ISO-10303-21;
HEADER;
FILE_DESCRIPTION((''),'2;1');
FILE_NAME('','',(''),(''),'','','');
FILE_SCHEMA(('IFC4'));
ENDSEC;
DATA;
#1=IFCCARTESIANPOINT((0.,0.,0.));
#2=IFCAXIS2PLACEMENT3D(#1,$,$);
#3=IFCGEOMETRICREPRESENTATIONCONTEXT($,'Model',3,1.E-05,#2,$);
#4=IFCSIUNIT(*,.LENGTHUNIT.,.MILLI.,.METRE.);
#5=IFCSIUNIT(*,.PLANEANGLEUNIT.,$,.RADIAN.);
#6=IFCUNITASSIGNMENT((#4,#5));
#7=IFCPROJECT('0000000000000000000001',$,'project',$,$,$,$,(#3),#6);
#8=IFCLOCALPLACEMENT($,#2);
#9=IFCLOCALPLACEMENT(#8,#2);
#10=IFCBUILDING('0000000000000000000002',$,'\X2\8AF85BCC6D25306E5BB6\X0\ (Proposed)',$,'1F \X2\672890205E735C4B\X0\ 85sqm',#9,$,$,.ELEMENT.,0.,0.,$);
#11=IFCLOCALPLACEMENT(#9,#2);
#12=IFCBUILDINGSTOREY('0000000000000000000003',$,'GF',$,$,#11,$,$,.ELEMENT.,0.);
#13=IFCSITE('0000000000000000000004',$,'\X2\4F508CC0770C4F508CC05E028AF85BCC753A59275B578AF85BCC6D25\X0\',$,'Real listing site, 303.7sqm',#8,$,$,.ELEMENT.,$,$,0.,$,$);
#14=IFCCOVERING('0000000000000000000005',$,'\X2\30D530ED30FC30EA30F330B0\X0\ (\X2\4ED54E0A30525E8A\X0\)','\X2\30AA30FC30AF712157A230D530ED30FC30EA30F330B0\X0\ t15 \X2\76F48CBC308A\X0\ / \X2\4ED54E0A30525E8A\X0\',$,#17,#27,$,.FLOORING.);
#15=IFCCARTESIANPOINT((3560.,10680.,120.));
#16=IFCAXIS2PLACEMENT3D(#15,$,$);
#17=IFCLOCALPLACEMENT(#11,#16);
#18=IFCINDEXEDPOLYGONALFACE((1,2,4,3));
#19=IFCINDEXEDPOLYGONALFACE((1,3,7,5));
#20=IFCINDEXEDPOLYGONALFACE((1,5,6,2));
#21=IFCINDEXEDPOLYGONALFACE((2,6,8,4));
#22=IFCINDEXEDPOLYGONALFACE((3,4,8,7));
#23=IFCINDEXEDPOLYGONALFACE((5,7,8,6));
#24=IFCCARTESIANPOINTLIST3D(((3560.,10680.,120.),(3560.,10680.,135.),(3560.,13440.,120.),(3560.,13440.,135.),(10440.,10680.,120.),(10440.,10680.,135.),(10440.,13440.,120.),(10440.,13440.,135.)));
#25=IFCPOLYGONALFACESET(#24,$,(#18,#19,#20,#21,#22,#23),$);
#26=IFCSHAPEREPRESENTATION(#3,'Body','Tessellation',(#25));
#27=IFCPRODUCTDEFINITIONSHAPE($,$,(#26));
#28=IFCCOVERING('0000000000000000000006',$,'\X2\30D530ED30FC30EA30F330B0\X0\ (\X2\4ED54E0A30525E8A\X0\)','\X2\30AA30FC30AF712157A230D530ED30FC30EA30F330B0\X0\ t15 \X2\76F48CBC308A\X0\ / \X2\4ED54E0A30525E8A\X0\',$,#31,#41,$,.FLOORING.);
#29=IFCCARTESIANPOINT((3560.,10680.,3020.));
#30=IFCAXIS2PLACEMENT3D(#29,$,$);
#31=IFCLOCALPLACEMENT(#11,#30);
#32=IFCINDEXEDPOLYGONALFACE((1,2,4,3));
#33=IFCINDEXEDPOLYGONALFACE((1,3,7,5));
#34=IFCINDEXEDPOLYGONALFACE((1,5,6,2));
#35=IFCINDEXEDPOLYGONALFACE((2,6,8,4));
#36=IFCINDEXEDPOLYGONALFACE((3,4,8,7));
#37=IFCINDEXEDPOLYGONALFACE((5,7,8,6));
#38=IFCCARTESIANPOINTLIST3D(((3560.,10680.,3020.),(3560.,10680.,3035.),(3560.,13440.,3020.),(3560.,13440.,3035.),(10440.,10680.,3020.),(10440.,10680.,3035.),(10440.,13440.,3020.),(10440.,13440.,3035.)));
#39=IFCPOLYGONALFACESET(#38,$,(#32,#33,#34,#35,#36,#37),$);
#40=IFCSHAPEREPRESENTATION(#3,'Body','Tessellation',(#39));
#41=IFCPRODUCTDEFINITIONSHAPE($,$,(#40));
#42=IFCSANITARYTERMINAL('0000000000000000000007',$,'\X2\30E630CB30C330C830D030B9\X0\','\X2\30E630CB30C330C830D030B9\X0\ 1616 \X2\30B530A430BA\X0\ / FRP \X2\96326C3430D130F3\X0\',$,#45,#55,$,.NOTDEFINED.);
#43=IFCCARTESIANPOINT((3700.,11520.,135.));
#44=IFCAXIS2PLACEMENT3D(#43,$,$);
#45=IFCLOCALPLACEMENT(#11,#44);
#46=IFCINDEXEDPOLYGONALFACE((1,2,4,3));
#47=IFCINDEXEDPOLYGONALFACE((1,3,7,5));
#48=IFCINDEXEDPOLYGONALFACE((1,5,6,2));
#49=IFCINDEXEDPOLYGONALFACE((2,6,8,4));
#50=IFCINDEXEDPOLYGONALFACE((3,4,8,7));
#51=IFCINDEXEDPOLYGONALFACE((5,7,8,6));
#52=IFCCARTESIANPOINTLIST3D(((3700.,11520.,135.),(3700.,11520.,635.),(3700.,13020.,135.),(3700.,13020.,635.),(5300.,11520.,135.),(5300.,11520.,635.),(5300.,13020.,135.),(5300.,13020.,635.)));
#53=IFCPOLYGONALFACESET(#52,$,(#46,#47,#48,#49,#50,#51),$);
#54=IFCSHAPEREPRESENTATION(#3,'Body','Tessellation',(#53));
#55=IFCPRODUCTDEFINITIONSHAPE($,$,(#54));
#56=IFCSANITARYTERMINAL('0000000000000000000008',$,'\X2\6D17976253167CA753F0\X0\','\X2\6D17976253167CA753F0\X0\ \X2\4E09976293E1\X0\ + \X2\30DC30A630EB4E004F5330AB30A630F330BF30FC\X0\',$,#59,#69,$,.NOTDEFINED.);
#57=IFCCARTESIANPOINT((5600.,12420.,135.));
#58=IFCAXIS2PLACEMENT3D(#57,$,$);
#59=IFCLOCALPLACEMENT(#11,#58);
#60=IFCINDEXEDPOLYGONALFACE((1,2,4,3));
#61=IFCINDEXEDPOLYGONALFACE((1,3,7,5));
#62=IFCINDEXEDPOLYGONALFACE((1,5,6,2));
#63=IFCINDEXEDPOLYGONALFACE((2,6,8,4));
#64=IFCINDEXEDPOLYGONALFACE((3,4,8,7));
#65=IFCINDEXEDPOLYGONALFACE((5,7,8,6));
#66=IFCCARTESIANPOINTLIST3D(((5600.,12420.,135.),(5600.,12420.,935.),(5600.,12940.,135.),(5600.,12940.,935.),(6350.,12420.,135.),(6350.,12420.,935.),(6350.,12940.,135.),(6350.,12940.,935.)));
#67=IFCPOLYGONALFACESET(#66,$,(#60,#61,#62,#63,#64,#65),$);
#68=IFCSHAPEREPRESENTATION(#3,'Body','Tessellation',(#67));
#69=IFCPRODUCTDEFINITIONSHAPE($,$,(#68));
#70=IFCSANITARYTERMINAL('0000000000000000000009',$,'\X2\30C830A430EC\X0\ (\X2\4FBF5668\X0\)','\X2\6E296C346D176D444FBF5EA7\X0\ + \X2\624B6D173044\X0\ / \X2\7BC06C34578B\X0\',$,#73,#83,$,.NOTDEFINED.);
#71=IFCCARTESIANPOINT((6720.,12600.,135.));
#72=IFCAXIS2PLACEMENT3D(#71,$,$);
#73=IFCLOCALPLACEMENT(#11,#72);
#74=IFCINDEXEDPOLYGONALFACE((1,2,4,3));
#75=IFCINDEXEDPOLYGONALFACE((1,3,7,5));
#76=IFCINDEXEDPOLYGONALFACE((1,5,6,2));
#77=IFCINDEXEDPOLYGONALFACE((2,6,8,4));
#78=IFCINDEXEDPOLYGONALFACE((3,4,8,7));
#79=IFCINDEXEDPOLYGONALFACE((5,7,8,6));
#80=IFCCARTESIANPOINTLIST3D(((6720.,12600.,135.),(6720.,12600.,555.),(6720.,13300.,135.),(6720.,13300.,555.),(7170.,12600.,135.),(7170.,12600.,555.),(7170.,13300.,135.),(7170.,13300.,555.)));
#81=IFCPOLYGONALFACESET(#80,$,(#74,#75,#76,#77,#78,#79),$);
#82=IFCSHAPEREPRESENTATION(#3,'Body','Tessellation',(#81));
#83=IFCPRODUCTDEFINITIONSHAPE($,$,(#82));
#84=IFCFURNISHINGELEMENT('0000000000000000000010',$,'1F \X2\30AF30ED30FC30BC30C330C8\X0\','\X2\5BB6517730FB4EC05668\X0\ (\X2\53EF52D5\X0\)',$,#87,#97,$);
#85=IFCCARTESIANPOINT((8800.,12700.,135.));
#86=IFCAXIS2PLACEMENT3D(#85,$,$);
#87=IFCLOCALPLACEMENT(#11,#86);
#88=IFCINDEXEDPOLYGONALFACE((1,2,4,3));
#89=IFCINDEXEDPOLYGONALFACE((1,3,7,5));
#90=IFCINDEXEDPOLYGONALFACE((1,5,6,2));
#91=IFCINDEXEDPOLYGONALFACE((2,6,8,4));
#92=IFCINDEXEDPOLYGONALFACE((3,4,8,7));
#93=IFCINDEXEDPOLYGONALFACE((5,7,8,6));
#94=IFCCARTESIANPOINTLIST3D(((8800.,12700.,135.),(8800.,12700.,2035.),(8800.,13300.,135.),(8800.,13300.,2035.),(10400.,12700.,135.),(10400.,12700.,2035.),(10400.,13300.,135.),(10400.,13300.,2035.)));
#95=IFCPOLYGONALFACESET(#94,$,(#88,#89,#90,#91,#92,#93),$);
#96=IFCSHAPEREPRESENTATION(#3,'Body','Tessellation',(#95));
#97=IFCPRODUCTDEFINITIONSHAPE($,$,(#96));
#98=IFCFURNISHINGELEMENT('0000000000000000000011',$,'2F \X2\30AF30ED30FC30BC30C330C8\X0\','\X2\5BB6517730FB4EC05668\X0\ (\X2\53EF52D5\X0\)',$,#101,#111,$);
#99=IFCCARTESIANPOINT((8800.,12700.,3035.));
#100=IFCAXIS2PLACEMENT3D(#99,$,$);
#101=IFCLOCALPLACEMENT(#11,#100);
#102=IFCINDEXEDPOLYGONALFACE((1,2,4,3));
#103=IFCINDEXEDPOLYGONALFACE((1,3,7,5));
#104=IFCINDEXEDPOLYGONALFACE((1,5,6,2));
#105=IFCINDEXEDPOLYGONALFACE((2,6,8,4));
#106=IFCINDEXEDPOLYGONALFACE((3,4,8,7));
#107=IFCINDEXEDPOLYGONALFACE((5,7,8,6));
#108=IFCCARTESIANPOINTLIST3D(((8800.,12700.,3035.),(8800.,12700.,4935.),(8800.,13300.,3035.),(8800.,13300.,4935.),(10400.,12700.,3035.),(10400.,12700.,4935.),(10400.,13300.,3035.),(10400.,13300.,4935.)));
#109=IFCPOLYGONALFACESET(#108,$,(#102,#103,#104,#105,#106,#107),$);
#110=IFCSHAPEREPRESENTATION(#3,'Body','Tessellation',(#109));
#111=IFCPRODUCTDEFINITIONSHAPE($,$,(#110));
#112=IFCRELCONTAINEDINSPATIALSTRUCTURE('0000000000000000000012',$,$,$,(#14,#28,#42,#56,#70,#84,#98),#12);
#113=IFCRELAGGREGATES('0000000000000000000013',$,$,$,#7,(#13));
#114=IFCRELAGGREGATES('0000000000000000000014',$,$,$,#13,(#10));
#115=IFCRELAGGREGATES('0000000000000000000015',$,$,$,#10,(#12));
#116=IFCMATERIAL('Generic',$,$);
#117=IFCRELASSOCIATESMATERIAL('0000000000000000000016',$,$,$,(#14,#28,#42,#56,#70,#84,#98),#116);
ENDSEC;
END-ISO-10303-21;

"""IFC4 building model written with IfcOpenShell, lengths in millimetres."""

from ifc_helpers import new_model, si_unit, frame, frame_2d, origin, place, context, project, spatial, rectangle, extrude, material, element, save


model = new_model("IFC4")

# Units and contexts
model_context = context("Model", 3, precision=1e-05, world=origin())
ifc_project = project(units=[si_unit("LENGTHUNIT", "METRE", prefix="MILLI"), si_unit("PLANEANGLEUNIT", "RADIAN")], contexts=[model_context])

# Site, building, storey
site_placement = place(None, origin())
site = spatial("IfcSite", under=ifc_project, at=site_placement, Name="佐賀県佐賀市諸富町大字諸富津", ObjectType="Real listing site, 303.7sqm", CompositionType="ELEMENT", RefElevation=0.0)
building_placement = place(site_placement, origin())
building = spatial("IfcBuilding", under=site, at=building_placement, Name="諸富津の家 (Proposed)", ObjectType="1F 木造平屋 85sqm", CompositionType="ELEMENT", ElevationOfRefHeight=0.0, ElevationOfTerrain=0.0)
storey_placement = place(building_placement, origin())
storey = spatial("IfcBuildingStorey", under=building, at=storey_placement, Name="GF", CompositionType="ELEMENT", Elevation=0.0)

# Coverings
ifc_material_1 = material(Name="Generic")
covering_1_placement = place(storey_placement, frame((3560.0, 10680.0, 120.0)))
element("IfcCovering", 1, at=covering_1_placement, inside=storey, material=ifc_material_1, Name="フローリング (仕上げ床)", Description="オーク無垢フローリング t15 直貼り / 仕上げ床", PredefinedType="FLOORING", context=model_context, shape_type="SweptSolid", body=[
    extrude(rectangle(XDim=6880.0, YDim=2760.0, at=frame_2d((3440.0, 1380.0))), frame((3560.0, 10680.0, 120.0)), (0.0, 0.0, 1.0), 15.0),
])
covering_2_placement = place(storey_placement, frame((3560.0, 10680.0, 3020.0)))
element("IfcCovering", 2, at=covering_2_placement, inside=storey, material=ifc_material_1, Name="フローリング (仕上げ床)", Description="オーク無垢フローリング t15 直貼り / 仕上げ床", PredefinedType="FLOORING", context=model_context, shape_type="SweptSolid", body=[
    extrude(rectangle(XDim=6880.0, YDim=2760.0, at=frame_2d((3440.0, 1380.0))), frame((3560.0, 10680.0, 3020.0)), (0.0, 0.0, 1.0), 15.0),
])

# Sanitary terminals
sanitary_terminal_1_placement = place(storey_placement, frame((3700.0, 11520.0, 135.0)))
element("IfcSanitaryTerminal", 3, at=sanitary_terminal_1_placement, inside=storey, material=ifc_material_1, Name="ユニットバス", Description="ユニットバス 1616 サイズ / FRP 防水パン", PredefinedType="NOTDEFINED", context=model_context, shape_type="SweptSolid", body=[
    extrude(rectangle(XDim=1600.0, YDim=1500.0, at=frame_2d((800.0, 750.0))), frame((3700.0, 11520.0, 135.0)), (0.0, 0.0, 1.0), 500.0),
])
sanitary_terminal_2_placement = place(storey_placement, frame((5600.0, 12420.0, 135.0)))
element("IfcSanitaryTerminal", 4, at=sanitary_terminal_2_placement, inside=storey, material=ifc_material_1, Name="洗面化粧台", Description="洗面化粧台 三面鏡 + ボウル一体カウンター", PredefinedType="NOTDEFINED", context=model_context, shape_type="SweptSolid", body=[
    extrude(rectangle(XDim=750.0, YDim=520.0, at=frame_2d((375.0, 260.0))), frame((5600.0, 12420.0, 135.0)), (0.0, 0.0, 1.0), 800.0),
])
sanitary_terminal_3_placement = place(storey_placement, frame((6720.0, 12600.0, 135.0)))
element("IfcSanitaryTerminal", 5, at=sanitary_terminal_3_placement, inside=storey, material=ifc_material_1, Name="トイレ (便器)", Description="温水洗浄便座 + 手洗い / 節水型", PredefinedType="NOTDEFINED", context=model_context, shape_type="SweptSolid", body=[
    extrude(rectangle(XDim=450.0, YDim=700.0, at=frame_2d((225.0, 350.0))), frame((6720.0, 12600.0, 135.0)), (0.0, 0.0, 1.0), 420.0),
])

# Furnishing elements
furnishing_1_placement = place(storey_placement, frame((8800.0, 12700.0, 135.0)))
element("IfcFurnishingElement", 6, at=furnishing_1_placement, inside=storey, material=ifc_material_1, Name="1F クローゼット", Description="家具・什器 (可動)", context=model_context, shape_type="SweptSolid", body=[
    extrude(rectangle(XDim=1600.0, YDim=600.0, at=frame_2d((800.0, 300.0))), frame((8800.0, 12700.0, 135.0)), (0.0, 0.0, 1.0), 1900.0),
])
furnishing_2_placement = place(storey_placement, frame((8800.0, 12700.0, 3035.0)))
element("IfcFurnishingElement", 7, at=furnishing_2_placement, inside=storey, material=ifc_material_1, Name="2F クローゼット", Description="家具・什器 (可動)", context=model_context, shape_type="SweptSolid", body=[
    extrude(rectangle(XDim=1600.0, YDim=600.0, at=frame_2d((800.0, 300.0))), frame((8800.0, 12700.0, 3035.0)), (0.0, 0.0, 1.0), 1900.0),
])

save(model, "model.ifc")
